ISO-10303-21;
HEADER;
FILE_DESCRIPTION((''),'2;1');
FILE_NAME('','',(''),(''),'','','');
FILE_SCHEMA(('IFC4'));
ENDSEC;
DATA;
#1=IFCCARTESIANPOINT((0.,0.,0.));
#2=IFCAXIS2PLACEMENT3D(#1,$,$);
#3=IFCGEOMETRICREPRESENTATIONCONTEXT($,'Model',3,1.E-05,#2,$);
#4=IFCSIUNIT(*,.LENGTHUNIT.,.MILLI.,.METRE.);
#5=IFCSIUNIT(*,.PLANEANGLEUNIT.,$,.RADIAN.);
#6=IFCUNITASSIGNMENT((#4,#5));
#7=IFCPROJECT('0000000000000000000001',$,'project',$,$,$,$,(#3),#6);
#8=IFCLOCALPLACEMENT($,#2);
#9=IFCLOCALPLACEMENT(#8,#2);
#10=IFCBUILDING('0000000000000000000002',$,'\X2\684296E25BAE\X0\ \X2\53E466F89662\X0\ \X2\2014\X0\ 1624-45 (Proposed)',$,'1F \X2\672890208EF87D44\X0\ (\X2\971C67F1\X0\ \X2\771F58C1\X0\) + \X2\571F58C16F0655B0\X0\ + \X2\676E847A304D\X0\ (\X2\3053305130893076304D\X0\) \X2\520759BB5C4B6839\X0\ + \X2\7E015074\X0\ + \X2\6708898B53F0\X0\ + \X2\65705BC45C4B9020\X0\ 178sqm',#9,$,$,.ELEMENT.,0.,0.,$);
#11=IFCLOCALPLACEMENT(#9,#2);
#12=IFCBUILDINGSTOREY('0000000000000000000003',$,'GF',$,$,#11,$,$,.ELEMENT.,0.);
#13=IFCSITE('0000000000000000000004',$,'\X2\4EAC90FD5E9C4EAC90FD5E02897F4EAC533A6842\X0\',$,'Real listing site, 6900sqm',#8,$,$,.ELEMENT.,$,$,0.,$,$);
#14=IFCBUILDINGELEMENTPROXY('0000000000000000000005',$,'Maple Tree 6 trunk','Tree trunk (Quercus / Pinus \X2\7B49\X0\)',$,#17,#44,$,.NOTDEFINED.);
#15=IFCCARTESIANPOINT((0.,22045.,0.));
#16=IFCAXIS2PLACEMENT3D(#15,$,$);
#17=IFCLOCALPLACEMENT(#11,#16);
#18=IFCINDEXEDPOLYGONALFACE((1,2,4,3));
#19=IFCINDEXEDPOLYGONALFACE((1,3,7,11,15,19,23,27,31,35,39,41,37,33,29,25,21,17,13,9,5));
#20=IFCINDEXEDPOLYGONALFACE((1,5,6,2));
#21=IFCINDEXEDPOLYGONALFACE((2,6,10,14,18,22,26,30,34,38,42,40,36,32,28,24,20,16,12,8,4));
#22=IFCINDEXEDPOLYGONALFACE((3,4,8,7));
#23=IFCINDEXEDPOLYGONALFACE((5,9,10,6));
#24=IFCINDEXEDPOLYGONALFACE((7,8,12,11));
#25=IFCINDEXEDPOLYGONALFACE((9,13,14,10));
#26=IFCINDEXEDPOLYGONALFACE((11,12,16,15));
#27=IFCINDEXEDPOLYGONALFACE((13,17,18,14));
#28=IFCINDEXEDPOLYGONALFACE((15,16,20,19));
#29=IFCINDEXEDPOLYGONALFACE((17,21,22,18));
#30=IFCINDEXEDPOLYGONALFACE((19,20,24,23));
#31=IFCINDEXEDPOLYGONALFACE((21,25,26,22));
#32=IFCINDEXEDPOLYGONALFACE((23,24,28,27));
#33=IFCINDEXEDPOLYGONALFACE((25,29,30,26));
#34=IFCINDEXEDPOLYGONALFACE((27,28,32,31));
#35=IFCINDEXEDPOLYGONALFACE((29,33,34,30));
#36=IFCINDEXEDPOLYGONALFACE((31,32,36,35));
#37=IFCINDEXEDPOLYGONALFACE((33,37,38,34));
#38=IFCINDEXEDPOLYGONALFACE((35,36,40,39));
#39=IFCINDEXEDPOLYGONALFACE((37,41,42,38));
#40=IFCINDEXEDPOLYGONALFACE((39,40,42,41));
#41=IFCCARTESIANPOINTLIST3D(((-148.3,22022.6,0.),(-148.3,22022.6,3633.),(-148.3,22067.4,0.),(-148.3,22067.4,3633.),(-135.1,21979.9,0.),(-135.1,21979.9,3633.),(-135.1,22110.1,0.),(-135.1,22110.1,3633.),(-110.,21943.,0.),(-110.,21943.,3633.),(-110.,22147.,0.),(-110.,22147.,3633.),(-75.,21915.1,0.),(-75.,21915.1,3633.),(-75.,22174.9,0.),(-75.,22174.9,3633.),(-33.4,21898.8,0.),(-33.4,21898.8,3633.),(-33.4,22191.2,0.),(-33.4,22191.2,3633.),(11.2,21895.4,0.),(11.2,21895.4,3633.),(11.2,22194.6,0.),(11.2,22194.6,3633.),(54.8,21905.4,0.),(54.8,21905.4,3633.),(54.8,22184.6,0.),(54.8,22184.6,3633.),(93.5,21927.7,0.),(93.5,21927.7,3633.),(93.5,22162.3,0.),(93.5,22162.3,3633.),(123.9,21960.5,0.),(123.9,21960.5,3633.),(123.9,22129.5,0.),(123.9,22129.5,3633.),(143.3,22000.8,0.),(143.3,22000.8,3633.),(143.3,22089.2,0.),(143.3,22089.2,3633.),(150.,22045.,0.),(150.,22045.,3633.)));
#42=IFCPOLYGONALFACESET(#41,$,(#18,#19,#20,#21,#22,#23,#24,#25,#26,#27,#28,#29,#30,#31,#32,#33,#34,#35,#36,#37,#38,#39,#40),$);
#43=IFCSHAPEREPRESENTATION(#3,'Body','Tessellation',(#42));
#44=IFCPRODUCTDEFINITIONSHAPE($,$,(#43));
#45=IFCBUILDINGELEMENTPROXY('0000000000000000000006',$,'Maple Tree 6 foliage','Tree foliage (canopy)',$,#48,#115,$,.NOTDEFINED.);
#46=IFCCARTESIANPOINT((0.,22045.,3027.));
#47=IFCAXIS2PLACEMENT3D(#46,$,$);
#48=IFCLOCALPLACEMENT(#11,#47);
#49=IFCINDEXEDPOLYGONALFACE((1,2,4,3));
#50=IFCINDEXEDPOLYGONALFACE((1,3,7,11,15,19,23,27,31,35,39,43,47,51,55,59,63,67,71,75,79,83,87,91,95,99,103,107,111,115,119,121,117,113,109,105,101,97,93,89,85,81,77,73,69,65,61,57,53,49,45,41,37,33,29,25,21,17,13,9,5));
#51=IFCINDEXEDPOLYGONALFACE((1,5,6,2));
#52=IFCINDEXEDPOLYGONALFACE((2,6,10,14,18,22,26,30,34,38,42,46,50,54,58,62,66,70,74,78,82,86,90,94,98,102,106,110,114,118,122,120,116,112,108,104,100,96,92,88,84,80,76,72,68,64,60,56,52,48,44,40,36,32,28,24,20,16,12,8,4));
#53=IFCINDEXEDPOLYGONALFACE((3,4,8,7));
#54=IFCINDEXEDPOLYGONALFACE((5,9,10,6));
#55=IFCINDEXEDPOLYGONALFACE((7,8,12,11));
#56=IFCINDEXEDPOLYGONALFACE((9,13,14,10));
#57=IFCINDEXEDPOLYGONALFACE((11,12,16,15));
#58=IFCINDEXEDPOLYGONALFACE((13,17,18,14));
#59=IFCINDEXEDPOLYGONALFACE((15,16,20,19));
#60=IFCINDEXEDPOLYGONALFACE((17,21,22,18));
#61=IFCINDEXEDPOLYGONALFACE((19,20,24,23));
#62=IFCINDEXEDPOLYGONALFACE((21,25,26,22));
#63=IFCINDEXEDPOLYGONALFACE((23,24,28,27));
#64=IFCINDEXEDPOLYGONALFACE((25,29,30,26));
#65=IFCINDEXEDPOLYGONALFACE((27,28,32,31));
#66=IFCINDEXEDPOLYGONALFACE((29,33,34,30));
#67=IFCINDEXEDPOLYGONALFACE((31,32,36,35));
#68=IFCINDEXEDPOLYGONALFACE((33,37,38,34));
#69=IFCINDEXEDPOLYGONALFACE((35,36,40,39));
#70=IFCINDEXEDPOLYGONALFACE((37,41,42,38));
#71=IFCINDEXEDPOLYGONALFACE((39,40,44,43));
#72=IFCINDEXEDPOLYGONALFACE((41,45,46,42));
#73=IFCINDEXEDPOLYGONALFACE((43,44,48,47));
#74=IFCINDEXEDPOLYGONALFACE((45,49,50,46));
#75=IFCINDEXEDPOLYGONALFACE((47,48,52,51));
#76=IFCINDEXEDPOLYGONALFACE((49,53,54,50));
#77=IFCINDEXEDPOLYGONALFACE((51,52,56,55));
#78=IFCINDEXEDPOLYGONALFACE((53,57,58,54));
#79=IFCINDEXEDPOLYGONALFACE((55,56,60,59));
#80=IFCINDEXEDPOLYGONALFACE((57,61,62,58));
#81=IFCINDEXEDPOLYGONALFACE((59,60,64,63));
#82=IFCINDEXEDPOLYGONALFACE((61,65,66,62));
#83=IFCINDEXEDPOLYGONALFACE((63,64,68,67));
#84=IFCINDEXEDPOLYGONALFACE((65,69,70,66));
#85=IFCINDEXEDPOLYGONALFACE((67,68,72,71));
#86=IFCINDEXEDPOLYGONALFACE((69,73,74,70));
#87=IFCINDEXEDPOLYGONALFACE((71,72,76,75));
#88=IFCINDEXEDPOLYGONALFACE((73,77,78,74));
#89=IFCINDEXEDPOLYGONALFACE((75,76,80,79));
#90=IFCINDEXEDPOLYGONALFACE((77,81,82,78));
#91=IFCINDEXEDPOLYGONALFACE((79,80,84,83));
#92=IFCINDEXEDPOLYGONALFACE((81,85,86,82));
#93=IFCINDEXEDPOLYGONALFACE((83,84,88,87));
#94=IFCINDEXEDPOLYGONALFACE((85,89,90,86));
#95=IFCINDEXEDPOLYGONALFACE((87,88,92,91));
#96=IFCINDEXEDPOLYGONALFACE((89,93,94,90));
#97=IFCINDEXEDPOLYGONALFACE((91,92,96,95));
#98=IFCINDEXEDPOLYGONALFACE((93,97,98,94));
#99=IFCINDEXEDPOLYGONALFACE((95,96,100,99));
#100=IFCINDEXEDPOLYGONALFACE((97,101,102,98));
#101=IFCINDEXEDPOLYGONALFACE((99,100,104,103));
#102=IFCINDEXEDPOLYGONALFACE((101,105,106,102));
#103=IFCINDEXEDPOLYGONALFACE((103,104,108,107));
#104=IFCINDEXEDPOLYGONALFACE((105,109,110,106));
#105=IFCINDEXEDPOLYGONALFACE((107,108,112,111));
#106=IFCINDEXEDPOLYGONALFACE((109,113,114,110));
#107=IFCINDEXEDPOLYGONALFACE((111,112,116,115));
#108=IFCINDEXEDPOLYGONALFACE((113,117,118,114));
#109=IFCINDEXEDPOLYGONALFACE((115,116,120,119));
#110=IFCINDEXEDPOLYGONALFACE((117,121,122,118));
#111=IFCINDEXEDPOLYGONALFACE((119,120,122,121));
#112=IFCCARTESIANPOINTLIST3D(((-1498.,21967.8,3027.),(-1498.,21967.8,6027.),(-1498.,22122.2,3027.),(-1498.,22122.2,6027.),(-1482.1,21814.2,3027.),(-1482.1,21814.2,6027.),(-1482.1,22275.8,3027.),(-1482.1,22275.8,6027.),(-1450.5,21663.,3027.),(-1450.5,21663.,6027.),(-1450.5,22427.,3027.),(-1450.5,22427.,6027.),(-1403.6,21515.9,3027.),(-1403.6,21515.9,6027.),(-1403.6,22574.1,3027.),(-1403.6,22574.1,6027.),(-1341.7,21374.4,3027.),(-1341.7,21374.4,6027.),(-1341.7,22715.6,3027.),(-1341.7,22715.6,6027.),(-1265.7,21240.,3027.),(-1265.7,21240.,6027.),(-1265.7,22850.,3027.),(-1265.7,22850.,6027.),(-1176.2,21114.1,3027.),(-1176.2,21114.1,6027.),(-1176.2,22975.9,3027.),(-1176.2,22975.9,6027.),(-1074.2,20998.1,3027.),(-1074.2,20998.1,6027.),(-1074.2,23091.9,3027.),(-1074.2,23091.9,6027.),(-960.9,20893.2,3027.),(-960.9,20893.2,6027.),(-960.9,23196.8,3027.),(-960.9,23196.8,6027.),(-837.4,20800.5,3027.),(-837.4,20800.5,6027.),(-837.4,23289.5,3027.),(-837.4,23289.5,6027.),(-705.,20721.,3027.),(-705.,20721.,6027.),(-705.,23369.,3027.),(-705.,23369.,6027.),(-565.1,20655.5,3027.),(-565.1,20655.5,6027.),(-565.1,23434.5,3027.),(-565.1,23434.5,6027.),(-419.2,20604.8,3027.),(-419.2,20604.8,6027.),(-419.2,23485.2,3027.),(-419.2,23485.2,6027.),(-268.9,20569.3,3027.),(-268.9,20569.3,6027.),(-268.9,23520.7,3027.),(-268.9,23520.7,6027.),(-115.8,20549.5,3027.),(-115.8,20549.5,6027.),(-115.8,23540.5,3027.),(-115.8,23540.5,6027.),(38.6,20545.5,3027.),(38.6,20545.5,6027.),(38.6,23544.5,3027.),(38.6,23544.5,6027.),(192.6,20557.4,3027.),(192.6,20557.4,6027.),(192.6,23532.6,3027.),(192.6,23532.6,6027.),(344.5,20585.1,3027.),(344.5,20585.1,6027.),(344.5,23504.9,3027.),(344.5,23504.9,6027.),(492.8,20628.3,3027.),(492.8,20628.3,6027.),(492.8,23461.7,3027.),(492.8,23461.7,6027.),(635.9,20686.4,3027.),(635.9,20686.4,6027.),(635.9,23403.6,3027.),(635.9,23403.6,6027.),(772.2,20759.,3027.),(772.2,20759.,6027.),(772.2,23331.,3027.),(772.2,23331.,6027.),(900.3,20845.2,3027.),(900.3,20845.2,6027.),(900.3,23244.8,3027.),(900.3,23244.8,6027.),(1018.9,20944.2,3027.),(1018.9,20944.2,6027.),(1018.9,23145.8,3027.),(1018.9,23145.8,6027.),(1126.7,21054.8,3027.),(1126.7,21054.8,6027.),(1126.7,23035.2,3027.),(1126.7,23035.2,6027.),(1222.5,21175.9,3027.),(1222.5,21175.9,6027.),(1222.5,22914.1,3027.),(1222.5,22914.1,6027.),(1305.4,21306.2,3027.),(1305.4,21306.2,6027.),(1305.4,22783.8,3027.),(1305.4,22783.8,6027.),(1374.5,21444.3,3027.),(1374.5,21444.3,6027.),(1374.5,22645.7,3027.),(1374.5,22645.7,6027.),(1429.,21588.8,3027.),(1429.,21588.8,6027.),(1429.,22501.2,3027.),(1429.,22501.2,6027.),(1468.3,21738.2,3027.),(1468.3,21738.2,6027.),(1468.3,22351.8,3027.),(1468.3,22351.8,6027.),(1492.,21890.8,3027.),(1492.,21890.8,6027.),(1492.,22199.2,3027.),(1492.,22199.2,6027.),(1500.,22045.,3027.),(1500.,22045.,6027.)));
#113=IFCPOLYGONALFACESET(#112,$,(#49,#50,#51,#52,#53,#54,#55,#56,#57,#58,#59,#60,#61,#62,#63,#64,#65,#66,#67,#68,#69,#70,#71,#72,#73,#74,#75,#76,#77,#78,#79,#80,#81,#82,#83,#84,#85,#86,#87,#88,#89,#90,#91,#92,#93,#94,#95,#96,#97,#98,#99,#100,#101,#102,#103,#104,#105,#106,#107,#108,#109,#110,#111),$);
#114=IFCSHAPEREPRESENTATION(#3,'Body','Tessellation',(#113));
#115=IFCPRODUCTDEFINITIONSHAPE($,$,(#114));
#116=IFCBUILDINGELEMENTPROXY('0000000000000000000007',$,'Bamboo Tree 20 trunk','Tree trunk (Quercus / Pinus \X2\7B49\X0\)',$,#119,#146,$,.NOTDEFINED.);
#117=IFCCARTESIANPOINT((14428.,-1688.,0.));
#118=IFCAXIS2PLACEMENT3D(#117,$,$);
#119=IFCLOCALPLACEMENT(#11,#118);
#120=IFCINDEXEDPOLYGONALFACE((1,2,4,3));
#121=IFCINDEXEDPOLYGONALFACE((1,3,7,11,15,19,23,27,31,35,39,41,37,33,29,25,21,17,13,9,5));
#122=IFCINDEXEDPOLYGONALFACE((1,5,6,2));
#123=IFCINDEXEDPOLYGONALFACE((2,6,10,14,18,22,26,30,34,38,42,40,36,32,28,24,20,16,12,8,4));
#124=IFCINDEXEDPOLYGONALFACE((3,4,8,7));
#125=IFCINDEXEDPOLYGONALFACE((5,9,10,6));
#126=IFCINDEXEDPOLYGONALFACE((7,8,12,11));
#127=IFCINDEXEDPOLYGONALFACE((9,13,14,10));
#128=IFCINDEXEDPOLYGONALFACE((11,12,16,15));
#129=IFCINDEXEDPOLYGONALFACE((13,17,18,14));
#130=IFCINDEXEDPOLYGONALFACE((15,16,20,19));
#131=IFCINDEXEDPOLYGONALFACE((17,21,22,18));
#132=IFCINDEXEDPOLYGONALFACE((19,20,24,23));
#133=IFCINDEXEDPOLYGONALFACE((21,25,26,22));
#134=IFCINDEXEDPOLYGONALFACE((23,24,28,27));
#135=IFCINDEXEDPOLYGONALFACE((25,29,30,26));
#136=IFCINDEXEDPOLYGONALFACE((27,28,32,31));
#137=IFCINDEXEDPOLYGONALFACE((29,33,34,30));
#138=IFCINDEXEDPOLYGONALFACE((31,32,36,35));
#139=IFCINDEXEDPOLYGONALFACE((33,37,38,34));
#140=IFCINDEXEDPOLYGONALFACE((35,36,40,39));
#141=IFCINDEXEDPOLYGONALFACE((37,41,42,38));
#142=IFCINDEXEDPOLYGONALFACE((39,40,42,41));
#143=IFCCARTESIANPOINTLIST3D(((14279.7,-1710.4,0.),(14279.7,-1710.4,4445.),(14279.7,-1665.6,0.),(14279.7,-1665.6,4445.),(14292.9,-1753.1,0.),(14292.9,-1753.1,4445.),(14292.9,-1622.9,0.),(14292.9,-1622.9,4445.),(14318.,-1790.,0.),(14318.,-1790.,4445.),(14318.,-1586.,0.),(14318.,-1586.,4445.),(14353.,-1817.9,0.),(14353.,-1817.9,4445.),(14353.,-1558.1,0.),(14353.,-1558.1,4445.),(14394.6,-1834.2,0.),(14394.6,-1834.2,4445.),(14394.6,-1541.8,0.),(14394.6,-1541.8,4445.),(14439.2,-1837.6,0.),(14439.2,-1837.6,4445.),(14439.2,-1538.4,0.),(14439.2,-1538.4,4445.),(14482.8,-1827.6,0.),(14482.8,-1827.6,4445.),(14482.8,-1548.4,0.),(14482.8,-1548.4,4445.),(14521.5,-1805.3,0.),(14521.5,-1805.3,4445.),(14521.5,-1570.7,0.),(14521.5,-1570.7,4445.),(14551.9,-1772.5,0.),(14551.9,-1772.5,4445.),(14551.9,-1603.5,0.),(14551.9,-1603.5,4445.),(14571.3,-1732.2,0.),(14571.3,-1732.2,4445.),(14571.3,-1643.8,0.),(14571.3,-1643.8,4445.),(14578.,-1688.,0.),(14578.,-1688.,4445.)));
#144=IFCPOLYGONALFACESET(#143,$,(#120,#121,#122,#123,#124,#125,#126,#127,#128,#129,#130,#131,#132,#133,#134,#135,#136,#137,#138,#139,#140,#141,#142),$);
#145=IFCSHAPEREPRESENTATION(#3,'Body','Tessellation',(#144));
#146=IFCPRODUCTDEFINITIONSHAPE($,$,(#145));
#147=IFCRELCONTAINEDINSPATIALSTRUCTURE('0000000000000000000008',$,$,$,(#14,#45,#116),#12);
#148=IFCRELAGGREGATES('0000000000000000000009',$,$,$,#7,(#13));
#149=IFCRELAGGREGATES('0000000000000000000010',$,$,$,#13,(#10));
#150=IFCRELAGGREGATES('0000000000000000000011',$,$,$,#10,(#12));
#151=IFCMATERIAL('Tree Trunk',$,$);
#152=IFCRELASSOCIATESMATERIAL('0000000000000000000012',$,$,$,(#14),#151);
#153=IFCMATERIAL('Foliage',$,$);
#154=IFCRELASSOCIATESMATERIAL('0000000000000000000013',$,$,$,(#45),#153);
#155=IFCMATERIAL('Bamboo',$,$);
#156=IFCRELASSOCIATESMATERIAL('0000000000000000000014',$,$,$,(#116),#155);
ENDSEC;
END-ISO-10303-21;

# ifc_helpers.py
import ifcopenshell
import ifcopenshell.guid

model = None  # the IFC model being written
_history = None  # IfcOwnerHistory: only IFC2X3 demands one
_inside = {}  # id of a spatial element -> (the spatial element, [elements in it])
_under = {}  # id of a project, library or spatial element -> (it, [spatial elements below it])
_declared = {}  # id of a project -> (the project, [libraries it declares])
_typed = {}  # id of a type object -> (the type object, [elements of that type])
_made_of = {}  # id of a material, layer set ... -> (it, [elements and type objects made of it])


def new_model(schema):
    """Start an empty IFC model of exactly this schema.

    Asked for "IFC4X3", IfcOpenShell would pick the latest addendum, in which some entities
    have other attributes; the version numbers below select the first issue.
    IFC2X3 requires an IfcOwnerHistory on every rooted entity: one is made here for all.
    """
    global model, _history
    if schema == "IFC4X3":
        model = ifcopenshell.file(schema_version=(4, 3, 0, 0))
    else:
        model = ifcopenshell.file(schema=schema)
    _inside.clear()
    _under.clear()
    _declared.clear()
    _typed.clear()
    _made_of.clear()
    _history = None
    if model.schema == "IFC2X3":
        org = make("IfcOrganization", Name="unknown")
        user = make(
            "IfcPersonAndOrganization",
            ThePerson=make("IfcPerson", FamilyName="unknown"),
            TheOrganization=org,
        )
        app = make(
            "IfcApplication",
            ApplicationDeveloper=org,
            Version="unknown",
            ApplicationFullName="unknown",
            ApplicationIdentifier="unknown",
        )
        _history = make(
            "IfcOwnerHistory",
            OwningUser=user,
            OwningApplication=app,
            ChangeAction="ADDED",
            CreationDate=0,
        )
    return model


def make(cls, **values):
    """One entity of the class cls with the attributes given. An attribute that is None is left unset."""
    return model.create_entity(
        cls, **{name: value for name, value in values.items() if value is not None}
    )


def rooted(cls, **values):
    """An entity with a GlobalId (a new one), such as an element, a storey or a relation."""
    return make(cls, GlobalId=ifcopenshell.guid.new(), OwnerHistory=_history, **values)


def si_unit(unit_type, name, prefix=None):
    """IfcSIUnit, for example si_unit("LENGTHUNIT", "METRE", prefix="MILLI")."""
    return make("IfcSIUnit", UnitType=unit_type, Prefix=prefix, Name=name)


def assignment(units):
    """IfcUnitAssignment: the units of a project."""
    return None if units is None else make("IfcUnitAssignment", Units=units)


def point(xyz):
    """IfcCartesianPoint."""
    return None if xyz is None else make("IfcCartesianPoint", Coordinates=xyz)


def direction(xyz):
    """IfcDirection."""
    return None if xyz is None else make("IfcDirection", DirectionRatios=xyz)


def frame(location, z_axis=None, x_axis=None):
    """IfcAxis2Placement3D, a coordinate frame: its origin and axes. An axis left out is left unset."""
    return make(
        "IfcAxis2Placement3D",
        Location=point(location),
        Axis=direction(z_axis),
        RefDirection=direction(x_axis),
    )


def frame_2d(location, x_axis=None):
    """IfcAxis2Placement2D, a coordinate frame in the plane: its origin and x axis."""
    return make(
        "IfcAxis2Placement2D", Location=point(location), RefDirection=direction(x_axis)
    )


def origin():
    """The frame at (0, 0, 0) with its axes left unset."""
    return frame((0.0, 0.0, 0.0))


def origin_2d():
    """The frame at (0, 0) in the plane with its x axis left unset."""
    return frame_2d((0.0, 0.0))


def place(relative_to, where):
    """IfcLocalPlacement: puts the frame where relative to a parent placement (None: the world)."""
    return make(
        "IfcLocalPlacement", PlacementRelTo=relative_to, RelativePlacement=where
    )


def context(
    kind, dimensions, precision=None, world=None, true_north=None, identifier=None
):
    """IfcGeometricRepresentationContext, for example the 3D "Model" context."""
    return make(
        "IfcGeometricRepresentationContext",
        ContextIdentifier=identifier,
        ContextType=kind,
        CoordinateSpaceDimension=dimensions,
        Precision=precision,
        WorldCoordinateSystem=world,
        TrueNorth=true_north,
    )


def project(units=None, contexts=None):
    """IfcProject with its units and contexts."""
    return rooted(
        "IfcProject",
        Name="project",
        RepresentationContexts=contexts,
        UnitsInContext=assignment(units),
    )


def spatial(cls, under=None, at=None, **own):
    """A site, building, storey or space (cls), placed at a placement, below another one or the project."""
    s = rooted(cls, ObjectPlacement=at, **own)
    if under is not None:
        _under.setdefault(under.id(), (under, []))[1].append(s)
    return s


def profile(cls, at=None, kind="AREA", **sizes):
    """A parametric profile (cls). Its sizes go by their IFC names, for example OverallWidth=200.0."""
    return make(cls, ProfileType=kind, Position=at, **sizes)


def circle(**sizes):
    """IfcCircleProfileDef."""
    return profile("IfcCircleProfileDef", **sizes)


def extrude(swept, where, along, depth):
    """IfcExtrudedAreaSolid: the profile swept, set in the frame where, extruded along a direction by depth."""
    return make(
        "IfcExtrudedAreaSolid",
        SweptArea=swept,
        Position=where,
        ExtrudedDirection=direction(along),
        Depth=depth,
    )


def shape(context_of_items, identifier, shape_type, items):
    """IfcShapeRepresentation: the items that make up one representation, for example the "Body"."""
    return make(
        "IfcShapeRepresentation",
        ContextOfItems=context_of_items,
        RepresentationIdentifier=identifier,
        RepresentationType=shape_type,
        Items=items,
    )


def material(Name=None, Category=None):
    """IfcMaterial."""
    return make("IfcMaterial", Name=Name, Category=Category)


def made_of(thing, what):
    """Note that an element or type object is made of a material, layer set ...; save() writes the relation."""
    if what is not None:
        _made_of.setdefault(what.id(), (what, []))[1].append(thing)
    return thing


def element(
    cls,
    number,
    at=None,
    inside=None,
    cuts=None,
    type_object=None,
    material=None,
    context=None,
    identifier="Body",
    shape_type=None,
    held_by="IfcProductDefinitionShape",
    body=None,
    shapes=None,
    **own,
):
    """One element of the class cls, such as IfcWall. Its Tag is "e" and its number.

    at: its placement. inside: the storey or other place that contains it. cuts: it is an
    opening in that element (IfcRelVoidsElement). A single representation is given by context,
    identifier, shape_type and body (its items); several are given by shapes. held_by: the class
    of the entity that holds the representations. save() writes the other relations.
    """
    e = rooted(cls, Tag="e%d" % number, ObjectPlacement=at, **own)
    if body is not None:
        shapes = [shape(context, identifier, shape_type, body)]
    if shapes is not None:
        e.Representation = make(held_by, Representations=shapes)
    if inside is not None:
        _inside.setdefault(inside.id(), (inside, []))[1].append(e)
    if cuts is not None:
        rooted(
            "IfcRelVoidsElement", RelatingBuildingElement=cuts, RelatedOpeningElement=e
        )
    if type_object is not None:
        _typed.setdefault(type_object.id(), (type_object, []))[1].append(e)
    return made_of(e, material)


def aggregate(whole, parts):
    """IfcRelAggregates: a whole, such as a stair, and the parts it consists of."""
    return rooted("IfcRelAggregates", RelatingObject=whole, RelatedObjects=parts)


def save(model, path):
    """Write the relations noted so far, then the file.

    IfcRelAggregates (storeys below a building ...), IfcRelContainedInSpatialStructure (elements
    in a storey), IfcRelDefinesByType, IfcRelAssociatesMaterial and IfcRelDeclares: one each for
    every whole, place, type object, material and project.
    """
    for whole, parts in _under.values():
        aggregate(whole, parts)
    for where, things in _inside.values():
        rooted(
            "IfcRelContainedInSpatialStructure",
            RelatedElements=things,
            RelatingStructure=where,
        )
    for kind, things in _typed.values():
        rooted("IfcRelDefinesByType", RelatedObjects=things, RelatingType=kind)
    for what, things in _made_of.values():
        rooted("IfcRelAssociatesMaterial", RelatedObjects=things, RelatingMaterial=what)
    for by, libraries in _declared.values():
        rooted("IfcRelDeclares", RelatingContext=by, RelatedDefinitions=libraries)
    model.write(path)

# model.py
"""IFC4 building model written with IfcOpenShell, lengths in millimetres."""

from ifc_helpers import new_model, si_unit, frame, origin, origin_2d, place, context, project, spatial, circle, extrude, material, element, save


model = new_model("IFC4")

# Units and contexts
model_context = context("Model", 3, precision=1e-05, world=origin())
ifc_project = project(units=[si_unit("LENGTHUNIT", "METRE", prefix="MILLI"), si_unit("PLANEANGLEUNIT", "RADIAN")], contexts=[model_context])

# Site, building, storey
site_placement = place(None, origin())
site = spatial("IfcSite", under=ifc_project, at=site_placement, Name="京都府京都市西京区桂", ObjectType="Real listing site, 6900sqm", CompositionType="ELEMENT", RefElevation=0.0)
building_placement = place(site_placement, origin())
building = spatial("IfcBuilding", under=site, at=building_placement, Name="桂離宮 古書院 — 1624-45 (Proposed)", ObjectType="1F 木造軸組 (霜柱 真壁) + 土壁漆喰 + 杮葺き (こけらぶき) 切妻屋根 + 縁側 + 月見台 + 数寄屋造 178sqm", CompositionType="ELEMENT", ElevationOfRefHeight=0.0, ElevationOfTerrain=0.0)
storey_placement = place(building_placement, origin())
storey = spatial("IfcBuildingStorey", under=building, at=storey_placement, Name="GF", CompositionType="ELEMENT", Elevation=0.0)

# Building element proxies
ifc_material_1 = material(Name="Tree Trunk")
ifc_material_2 = material(Name="Foliage")
ifc_material_3 = material(Name="Bamboo")
proxy_1_placement = place(storey_placement, frame((0.0, 22045.0, 0.0)))
element("IfcBuildingElementProxy", 1, at=proxy_1_placement, inside=storey, material=ifc_material_1, Name="Maple Tree 6 trunk", Description="Tree trunk (Quercus / Pinus 等)", PredefinedType="NOTDEFINED", context=model_context, shape_type="SweptSolid", body=[
    extrude(circle(Radius=150.0, at=origin_2d()), frame((0.0, 22045.0, 0.0)), (0.0, 0.0, 1.0), 3633.0),
])
proxy_2_placement = place(storey_placement, frame((0.0, 22045.0, 3027.0)))
element("IfcBuildingElementProxy", 2, at=proxy_2_placement, inside=storey, material=ifc_material_2, Name="Maple Tree 6 foliage", Description="Tree foliage (canopy)", PredefinedType="NOTDEFINED", context=model_context, shape_type="SweptSolid", body=[
    extrude(circle(Radius=1500.0, at=origin_2d()), frame((0.0, 22045.0, 3027.0)), (0.0, 0.0, 1.0), 3000.0),
])
proxy_3_placement = place(storey_placement, frame((14428.0, -1688.0, 0.0)))
element("IfcBuildingElementProxy", 3, at=proxy_3_placement, inside=storey, material=ifc_material_3, Name="Bamboo Tree 20 trunk", Description="Tree trunk (Quercus / Pinus 等)", PredefinedType="NOTDEFINED", context=model_context, shape_type="SweptSolid", body=[
    extrude(circle(Radius=150.0, at=origin_2d()), frame((14428.0, -1688.0, 0.0)), (0.0, 0.0, 1.0), 4445.0),
])

save(model, "model.ifc")
